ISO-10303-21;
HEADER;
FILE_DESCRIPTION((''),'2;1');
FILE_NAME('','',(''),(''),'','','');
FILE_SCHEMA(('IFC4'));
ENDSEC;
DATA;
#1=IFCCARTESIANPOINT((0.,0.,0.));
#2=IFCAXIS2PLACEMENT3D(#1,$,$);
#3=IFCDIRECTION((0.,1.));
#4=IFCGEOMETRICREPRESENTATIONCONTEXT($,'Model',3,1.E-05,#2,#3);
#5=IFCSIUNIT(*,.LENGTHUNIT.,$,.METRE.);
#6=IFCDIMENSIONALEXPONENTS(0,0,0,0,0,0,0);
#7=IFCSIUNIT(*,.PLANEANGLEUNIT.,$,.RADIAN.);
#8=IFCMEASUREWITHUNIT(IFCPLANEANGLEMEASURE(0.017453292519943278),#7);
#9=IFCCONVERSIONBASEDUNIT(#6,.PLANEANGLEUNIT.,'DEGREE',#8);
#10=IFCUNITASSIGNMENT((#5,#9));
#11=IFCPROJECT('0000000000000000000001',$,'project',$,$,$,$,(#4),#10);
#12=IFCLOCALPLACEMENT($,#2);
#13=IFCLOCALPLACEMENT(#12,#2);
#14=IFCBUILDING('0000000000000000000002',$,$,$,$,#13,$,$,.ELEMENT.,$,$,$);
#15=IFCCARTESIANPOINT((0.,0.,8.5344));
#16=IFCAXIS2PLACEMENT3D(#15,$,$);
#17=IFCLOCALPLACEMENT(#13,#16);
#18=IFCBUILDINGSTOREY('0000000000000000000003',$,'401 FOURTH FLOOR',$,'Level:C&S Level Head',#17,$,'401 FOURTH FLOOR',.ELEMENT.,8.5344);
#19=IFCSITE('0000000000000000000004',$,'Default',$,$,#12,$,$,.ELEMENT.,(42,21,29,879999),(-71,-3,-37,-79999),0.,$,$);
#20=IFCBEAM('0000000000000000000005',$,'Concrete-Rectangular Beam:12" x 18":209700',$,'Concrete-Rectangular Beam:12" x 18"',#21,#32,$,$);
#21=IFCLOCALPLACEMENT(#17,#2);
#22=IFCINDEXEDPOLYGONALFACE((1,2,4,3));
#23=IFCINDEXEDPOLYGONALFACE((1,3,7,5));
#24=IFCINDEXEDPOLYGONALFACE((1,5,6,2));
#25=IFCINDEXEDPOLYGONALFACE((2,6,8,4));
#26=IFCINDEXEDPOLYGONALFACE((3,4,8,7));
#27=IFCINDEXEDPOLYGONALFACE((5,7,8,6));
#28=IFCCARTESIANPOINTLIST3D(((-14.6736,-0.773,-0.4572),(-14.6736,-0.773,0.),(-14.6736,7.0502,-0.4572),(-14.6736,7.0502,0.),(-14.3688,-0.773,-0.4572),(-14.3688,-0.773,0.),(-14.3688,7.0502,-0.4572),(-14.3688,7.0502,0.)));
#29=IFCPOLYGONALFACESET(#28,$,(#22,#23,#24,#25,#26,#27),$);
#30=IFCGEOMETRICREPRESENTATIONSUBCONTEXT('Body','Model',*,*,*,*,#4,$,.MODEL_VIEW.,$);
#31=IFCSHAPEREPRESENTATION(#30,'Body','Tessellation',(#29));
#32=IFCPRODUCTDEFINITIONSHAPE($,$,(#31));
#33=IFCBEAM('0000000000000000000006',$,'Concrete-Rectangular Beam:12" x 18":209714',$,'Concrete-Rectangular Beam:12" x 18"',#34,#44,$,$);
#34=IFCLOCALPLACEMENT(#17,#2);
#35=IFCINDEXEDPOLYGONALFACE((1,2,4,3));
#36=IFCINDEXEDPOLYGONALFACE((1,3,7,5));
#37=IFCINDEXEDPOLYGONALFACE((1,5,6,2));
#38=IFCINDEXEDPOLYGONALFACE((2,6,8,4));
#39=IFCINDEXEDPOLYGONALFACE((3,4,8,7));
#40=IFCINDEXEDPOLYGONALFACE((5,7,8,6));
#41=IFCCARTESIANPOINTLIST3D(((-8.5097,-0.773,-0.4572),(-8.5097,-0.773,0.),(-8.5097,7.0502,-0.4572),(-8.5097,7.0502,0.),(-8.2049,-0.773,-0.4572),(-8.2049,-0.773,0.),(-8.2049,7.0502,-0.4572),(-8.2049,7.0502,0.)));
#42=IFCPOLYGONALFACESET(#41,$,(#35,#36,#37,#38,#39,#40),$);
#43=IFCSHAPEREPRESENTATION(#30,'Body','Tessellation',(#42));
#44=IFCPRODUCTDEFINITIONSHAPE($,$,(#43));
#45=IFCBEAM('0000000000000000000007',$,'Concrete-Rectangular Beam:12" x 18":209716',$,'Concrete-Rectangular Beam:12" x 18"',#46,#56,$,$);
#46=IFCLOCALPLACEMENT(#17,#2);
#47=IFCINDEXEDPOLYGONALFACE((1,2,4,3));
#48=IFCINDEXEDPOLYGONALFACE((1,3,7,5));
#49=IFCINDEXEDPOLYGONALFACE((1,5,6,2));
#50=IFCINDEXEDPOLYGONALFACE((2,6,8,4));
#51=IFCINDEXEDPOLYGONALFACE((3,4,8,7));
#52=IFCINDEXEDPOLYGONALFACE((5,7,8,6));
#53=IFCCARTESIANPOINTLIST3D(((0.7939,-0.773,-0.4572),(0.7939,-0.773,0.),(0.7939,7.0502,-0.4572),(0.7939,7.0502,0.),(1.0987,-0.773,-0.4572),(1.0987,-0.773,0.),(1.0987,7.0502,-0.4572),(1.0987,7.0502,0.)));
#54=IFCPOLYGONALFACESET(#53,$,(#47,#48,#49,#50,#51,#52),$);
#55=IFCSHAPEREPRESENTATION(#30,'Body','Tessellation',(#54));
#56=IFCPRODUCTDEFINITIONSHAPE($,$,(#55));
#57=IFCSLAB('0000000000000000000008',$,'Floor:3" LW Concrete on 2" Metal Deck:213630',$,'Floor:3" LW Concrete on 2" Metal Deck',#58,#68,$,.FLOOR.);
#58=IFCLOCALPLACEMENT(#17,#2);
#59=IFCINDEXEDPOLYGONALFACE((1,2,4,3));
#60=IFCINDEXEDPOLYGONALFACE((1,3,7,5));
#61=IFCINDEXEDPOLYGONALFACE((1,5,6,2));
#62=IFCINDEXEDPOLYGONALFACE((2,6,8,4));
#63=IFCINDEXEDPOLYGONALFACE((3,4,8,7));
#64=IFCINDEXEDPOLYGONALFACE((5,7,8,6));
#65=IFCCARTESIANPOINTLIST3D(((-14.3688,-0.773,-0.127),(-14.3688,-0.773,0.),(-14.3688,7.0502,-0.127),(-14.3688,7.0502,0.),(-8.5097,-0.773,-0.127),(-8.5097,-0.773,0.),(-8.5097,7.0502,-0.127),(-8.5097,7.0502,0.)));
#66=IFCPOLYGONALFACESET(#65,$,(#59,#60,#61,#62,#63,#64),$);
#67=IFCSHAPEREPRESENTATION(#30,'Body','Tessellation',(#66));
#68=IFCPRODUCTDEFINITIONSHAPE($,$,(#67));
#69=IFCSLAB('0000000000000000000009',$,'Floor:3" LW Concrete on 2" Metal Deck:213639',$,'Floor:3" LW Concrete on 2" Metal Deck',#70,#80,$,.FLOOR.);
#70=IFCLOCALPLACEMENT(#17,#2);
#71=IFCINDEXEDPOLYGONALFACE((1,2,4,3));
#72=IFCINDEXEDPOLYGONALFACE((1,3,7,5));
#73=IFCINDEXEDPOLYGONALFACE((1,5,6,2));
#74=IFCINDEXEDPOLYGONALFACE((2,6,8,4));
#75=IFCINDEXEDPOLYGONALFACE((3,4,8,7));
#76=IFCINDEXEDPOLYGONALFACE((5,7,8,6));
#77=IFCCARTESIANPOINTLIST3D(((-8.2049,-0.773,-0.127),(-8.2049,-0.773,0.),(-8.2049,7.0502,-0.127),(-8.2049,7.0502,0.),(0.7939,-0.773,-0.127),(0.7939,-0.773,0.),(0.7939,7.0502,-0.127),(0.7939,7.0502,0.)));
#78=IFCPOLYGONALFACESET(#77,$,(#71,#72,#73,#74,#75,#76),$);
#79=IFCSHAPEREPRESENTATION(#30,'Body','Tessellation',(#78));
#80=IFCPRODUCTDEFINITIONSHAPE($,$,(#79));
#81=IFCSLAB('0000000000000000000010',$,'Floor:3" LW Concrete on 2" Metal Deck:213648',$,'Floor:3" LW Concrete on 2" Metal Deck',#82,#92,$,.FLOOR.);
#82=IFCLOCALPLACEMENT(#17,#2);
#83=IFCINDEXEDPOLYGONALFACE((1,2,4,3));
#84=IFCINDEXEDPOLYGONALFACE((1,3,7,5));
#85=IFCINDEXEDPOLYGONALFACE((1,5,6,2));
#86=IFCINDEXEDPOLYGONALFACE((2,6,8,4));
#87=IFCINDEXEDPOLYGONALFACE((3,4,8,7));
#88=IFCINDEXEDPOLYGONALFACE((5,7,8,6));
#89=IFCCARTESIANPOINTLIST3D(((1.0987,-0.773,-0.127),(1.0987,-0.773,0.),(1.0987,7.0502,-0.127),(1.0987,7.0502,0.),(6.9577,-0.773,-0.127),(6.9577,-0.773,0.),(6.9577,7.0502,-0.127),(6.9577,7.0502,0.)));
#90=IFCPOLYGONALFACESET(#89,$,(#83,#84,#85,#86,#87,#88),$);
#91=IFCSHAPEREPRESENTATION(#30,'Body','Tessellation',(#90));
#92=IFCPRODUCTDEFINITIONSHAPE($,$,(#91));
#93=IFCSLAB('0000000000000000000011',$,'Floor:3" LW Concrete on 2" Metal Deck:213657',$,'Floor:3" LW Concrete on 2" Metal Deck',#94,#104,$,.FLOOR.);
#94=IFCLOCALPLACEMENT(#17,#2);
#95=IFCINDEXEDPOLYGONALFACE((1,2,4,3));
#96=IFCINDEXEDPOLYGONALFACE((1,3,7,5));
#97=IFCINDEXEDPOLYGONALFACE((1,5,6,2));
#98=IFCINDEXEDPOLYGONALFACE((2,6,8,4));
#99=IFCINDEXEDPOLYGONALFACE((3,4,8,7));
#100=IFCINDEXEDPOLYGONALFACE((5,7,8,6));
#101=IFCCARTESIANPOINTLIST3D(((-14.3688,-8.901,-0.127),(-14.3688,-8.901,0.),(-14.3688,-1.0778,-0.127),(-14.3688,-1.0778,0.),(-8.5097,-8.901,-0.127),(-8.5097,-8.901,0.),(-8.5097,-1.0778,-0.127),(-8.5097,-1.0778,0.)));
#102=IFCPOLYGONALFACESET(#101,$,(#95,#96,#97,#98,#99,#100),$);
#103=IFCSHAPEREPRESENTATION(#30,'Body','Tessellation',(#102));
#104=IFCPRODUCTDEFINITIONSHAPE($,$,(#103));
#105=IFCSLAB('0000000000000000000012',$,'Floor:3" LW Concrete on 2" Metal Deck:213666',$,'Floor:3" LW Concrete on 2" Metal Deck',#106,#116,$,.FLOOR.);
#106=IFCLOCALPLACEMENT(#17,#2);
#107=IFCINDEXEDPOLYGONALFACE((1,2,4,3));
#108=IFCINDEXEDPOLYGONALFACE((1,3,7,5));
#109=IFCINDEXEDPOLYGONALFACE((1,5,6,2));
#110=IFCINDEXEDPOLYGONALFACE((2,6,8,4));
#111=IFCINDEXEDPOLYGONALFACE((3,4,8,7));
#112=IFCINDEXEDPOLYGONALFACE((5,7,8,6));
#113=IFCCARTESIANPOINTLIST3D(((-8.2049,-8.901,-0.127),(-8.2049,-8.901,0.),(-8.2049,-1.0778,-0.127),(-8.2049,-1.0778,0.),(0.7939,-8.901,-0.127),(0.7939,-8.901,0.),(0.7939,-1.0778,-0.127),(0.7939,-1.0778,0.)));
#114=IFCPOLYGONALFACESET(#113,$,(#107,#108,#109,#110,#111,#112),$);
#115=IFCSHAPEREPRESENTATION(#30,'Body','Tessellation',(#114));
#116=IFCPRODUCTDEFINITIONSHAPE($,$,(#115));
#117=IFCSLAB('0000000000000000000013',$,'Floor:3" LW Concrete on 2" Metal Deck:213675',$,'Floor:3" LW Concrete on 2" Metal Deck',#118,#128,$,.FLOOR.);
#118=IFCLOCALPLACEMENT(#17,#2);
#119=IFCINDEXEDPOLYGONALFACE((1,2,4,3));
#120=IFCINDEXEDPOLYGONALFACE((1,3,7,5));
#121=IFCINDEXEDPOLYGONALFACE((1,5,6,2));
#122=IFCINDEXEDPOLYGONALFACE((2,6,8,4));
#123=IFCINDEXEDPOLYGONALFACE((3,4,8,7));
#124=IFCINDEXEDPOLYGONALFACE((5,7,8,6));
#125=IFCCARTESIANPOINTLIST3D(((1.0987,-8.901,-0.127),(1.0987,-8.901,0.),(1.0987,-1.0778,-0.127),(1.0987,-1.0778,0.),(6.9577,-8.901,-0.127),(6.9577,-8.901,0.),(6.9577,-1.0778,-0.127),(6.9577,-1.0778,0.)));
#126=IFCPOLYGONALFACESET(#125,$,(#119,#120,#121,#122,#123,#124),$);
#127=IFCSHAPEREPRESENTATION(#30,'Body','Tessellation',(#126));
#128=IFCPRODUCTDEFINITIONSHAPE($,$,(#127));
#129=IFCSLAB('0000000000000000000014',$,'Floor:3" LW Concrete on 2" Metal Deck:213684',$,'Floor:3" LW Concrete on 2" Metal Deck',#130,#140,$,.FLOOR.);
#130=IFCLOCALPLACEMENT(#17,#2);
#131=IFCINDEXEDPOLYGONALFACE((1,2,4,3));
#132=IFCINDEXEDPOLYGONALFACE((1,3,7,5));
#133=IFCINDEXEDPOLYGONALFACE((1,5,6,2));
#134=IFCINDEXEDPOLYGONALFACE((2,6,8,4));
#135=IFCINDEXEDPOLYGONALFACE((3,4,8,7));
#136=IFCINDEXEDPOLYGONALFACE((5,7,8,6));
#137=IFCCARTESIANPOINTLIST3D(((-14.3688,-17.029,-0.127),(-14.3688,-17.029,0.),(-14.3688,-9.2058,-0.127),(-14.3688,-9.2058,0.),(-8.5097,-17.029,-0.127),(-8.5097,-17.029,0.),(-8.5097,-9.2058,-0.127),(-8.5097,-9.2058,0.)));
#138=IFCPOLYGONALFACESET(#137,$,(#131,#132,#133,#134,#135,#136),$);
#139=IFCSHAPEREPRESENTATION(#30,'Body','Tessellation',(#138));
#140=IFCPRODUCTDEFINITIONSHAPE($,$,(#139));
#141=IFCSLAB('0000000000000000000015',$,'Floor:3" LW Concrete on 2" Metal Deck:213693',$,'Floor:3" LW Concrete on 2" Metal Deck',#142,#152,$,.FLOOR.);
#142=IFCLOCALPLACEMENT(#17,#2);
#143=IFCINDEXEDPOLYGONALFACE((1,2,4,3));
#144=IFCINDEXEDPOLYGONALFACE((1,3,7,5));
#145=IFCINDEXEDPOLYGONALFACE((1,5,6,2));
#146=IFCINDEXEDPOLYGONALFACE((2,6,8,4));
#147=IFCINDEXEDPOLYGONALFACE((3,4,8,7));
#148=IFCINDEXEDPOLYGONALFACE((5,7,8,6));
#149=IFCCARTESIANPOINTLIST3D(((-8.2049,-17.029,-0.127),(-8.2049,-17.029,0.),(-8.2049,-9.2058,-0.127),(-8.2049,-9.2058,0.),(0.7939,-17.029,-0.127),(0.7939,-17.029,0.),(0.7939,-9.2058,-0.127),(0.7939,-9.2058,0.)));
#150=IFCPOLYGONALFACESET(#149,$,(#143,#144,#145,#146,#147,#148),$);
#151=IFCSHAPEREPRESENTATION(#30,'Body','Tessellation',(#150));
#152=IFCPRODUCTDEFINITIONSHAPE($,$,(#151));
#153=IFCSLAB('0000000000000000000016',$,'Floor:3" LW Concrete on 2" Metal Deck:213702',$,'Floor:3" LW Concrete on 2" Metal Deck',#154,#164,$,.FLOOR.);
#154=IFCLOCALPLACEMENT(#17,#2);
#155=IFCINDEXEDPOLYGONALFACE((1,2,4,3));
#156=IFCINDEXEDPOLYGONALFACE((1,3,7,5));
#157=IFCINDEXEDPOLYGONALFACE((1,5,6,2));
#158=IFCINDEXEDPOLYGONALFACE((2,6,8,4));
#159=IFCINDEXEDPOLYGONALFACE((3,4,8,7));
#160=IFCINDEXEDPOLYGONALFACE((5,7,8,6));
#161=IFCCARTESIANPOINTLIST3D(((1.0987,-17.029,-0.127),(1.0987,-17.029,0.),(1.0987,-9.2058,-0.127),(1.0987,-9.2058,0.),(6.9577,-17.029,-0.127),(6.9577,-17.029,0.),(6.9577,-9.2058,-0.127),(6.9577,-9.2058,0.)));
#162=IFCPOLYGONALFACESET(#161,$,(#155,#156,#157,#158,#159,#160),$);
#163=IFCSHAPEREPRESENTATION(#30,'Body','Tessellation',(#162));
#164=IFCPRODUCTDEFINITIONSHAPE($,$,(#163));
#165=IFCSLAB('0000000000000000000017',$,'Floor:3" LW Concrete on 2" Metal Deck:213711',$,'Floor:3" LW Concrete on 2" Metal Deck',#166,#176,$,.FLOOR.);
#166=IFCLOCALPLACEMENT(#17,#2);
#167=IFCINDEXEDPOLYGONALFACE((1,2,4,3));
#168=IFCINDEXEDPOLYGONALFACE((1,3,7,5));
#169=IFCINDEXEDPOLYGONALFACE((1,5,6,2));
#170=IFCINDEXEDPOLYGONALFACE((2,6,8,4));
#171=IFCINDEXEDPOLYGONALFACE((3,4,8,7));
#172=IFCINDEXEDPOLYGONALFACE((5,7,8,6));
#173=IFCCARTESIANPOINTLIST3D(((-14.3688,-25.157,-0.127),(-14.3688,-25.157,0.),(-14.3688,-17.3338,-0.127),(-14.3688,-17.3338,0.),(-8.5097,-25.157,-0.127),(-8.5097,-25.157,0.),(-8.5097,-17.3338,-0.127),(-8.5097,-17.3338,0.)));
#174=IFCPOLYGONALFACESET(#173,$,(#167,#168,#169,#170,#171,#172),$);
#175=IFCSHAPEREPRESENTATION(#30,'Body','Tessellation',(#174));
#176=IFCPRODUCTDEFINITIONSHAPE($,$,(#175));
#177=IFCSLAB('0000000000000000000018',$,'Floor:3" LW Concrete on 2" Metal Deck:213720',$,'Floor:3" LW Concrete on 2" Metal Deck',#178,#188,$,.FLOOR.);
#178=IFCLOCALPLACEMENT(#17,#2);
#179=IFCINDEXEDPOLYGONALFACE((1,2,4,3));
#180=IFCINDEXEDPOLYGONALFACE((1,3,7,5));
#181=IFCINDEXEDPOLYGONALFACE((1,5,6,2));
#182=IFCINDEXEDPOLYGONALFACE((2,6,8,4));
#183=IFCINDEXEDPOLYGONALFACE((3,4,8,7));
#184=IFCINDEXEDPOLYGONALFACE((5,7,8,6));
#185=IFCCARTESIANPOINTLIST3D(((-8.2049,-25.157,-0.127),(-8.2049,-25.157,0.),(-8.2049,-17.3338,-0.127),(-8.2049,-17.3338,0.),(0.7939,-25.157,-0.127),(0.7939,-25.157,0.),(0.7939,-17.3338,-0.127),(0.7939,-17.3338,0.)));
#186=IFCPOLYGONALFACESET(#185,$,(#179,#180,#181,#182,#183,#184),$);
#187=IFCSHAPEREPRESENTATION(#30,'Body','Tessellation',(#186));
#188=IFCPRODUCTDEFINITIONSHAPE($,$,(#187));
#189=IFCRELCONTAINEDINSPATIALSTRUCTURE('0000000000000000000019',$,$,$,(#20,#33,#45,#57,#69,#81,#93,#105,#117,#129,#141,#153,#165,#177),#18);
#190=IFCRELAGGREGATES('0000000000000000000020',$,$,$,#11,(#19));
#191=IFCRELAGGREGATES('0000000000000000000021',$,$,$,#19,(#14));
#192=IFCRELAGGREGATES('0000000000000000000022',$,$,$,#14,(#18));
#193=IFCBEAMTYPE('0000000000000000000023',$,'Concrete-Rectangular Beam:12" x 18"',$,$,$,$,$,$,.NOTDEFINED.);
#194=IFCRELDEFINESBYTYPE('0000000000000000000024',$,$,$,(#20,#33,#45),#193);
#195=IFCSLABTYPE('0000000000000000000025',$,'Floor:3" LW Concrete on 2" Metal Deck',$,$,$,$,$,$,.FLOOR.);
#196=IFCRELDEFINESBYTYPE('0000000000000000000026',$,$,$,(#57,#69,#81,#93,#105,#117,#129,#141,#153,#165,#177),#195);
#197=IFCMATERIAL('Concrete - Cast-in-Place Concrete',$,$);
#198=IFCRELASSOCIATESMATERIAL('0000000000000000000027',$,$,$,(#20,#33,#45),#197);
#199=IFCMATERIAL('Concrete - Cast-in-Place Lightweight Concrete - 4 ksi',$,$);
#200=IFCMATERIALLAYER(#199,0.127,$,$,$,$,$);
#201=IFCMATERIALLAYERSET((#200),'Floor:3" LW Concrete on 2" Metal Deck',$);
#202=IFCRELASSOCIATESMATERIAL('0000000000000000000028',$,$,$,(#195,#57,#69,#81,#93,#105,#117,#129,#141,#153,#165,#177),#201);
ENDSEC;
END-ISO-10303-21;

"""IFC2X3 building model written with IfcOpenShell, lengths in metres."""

from ifc_helpers import new_model, entity, si_unit, converted_unit, direction, frame, frame_2d, origin, origin_2d_with_axis, place, context, subcontext, project, spatial, rectangle, extrude, material, layer, layer_set, layer_usage, type_object, element, save


model = new_model("IFC2X3")

# Units and contexts
model_context = context("Model", 3, precision=1e-05, world=origin(), true_north=direction((0.0, 1.0)))
body_context = subcontext(model_context, "Body", "Model", "MODEL_VIEW")
ifc_project = project(units=[si_unit("LENGTHUNIT", "METRE"), converted_unit("PLANEANGLEUNIT", "DEGREE", entity("IfcPlaneAngleMeasure", 0.017453292519943278), si_unit("PLANEANGLEUNIT", "RADIAN"), dimensions=[0, 0, 0, 0, 0, 0, 0])], contexts=[model_context])

# Site, building, storey
site_placement = place(None, origin())
site = spatial("IfcSite", under=ifc_project, at=site_placement, Name="Default", CompositionType="ELEMENT", RefLatitude=(42, 21, 29, 879999), RefLongitude=(-71, -3, -37, -79999), RefElevation=0.0)
building_placement = place(site_placement, origin())
building = spatial("IfcBuilding", under=site, at=building_placement, CompositionType="ELEMENT")
storey_placement = place(building_placement, frame((0.0, 0.0, 8.5344)))
storey = spatial("IfcBuildingStorey", under=building, at=storey_placement, Name="401 FOURTH FLOOR", ObjectType="Level:C&S Level Head", LongName="401 FOURTH FLOOR", CompositionType="ELEMENT", Elevation=8.5344)

# Beams
ifc_material_1 = material(Name="Concrete - Cast-in-Place Concrete")
beam_type = type_object("IfcBeamType", Name="Concrete-Rectangular Beam:12\" x 18\"", PredefinedType="NOTDEFINED")
beam_1_placement = place(storey_placement, frame((-14.5212, 7.0502, 0.0), z_axis=(0.0, 0.0, 1.0), x_axis=(0.0, -1.0, 0.0)))
element("IfcBeam", 1, at=beam_1_placement, inside=storey, type_object=beam_type, material=ifc_material_1, Name="Concrete-Rectangular Beam:12\" x 18\":209700", ObjectType="Concrete-Rectangular Beam:12\" x 18\"", context=body_context, shape_type="SweptSolid", body=[
    extrude(rectangle(XDim=0.4572, YDim=0.3048, at=origin_2d_with_axis()), frame((0.0, 0.0, -0.2286), z_axis=(1.0, 0.0, 0.0), x_axis=(0.0, 0.0, -1.0)), (0.0, 0.0, 1.0), 7.8232),
])
beam_2_placement = place(storey_placement, frame((-8.3573, 7.0502, 0.0), z_axis=(0.0, 0.0, 1.0), x_axis=(0.0, -1.0, 0.0)))
element("IfcBeam", 2, at=beam_2_placement, inside=storey, type_object=beam_type, material=ifc_material_1, Name="Concrete-Rectangular Beam:12\" x 18\":209714", ObjectType="Concrete-Rectangular Beam:12\" x 18\"", context=body_context, shape_type="SweptSolid", body=[
    extrude(rectangle(XDim=0.4572, YDim=0.3048, at=frame_2d((0.0, 0.0), x_axis=(1.0, 0.0))), frame((0.0, 0.0, -0.2286), z_axis=(1.0, 0.0, 0.0), x_axis=(0.0, 0.0, -1.0)), (0.0, 0.0, 1.0), 7.8232),
])
beam_3_placement = place(storey_placement, frame((0.9463, 7.0502, 0.0), z_axis=(0.0, 0.0, 1.0), x_axis=(0.0, -1.0, 0.0)))
element("IfcBeam", 3, at=beam_3_placement, inside=storey, type_object=beam_type, material=ifc_material_1, Name="Concrete-Rectangular Beam:12\" x 18\":209716", ObjectType="Concrete-Rectangular Beam:12\" x 18\"", context=body_context, shape_type="SweptSolid", body=[
    extrude(rectangle(XDim=0.4572, YDim=0.3048, at=origin_2d_with_axis()), frame((0.0, 0.0, -0.2286), z_axis=(1.0, 0.0, 0.0), x_axis=(0.0, 0.0, -1.0)), (0.0, 0.0, 1.0), 7.8232),
])

# Slabs
ifc_material_2 = material(Name="Concrete - Cast-in-Place Lightweight Concrete - 4 ksi")
ifc_layer = layer(ifc_material_2, 0.127)
ifc_layer_set = layer_set([ifc_layer], Name="Floor:3\" LW Concrete on 2\" Metal Deck")
ifc_layer_usage_1 = layer_usage(ifc_layer_set, "AXIS3", "POSITIVE", 0.0)
slab_type = type_object("IfcSlabType", Name="Floor:3\" LW Concrete on 2\" Metal Deck", PredefinedType="FLOOR", material=ifc_layer_set)
slab_1_placement = place(storey_placement, origin())
element("IfcSlab", 4, at=slab_1_placement, inside=storey, type_object=slab_type, material=ifc_layer_usage_1, Name="Floor:3\" LW Concrete on 2\" Metal Deck:213630", ObjectType="Floor:3\" LW Concrete on 2\" Metal Deck", PredefinedType="FLOOR", context=body_context, shape_type="SweptSolid", body=[
    extrude(rectangle(XDim=7.8232, YDim=5.859, at=frame_2d((0.0, 0.0), x_axis=(1.0, 0.0))), frame((-11.4393, 3.1386, 0.0), z_axis=(0.0, 0.0, -1.0), x_axis=(0.0, 1.0, 0.0)), (0.0, 0.0, 1.0), 0.127),
])
ifc_layer_usage_2 = layer_usage(ifc_layer_set, "AXIS3", "POSITIVE", 0.0)
slab_2_placement = place(storey_placement, origin())
element("IfcSlab", 5, at=slab_2_placement, inside=storey, type_object=slab_type, material=ifc_layer_usage_2, Name="Floor:3\" LW Concrete on 2\" Metal Deck:213639", ObjectType="Floor:3\" LW Concrete on 2\" Metal Deck", PredefinedType="FLOOR", context=body_context, shape_type="SweptSolid", body=[
    extrude(rectangle(XDim=7.8232, YDim=8.9988, at=origin_2d_with_axis()), frame((-3.7055, 3.1386, 0.0), z_axis=(0.0, 0.0, -1.0), x_axis=(0.0, 1.0, 0.0)), (0.0, 0.0, 1.0), 0.127),
])
ifc_layer_usage_3 = layer_usage(ifc_layer_set, "AXIS3", "POSITIVE", 0.0)
slab_3_placement = place(storey_placement, origin())
element("IfcSlab", 6, at=slab_3_placement, inside=storey, type_object=slab_type, material=ifc_layer_usage_3, Name="Floor:3\" LW Concrete on 2\" Metal Deck:213648", ObjectType="Floor:3\" LW Concrete on 2\" Metal Deck", PredefinedType="FLOOR", context=body_context, shape_type="SweptSolid", body=[
    extrude(rectangle(XDim=7.8232, YDim=5.859, at=origin_2d_with_axis()), frame((4.0282, 3.1386, 0.0), z_axis=(0.0, 0.0, -1.0), x_axis=(0.0, 1.0, 0.0)), (0.0, 0.0, 1.0), 0.127),
])
ifc_layer_usage_4 = layer_usage(ifc_layer_set, "AXIS3", "POSITIVE", 0.0)
slab_4_placement = place(storey_placement, origin())
element("IfcSlab", 7, at=slab_4_placement, inside=storey, type_object=slab_type, material=ifc_layer_usage_4, Name="Floor:3\" LW Concrete on 2\" Metal Deck:213657", ObjectType="Floor:3\" LW Concrete on 2\" Metal Deck", PredefinedType="FLOOR", context=body_context, shape_type="SweptSolid", body=[
    extrude(rectangle(XDim=7.8232, YDim=5.859, at=origin_2d_with_axis()), frame((-11.4393, -4.9894, 0.0), z_axis=(0.0, 0.0, -1.0), x_axis=(0.0, 1.0, 0.0)), (0.0, 0.0, 1.0), 0.127),
])
ifc_layer_usage_5 = layer_usage(ifc_layer_set, "AXIS3", "POSITIVE", 0.0)
slab_5_placement = place(storey_placement, origin())
element("IfcSlab", 8, at=slab_5_placement, inside=storey, type_object=slab_type, material=ifc_layer_usage_5, Name="Floor:3\" LW Concrete on 2\" Metal Deck:213666", ObjectType="Floor:3\" LW Concrete on 2\" Metal Deck", PredefinedType="FLOOR", context=body_context, shape_type="SweptSolid", body=[
    extrude(rectangle(XDim=7.8232, YDim=8.9988, at=frame_2d((0.0, 0.0), x_axis=(1.0, 0.0))), frame((-3.7055, -4.9894, 0.0), z_axis=(0.0, 0.0, -1.0), x_axis=(0.0, 1.0, 0.0)), (0.0, 0.0, 1.0), 0.127),
])
ifc_layer_usage_6 = layer_usage(ifc_layer_set, "AXIS3", "POSITIVE", 0.0)
slab_6_placement = place(storey_placement, origin())
element("IfcSlab", 9, at=slab_6_placement, inside=storey, type_object=slab_type, material=ifc_layer_usage_6, Name="Floor:3\" LW Concrete on 2\" Metal Deck:213675", ObjectType="Floor:3\" LW Concrete on 2\" Metal Deck", PredefinedType="FLOOR", context=body_context, shape_type="SweptSolid", body=[
    extrude(rectangle(XDim=7.8232, YDim=5.859, at=origin_2d_with_axis()), frame((4.0282, -4.9894, 0.0), z_axis=(0.0, 0.0, -1.0), x_axis=(0.0, 1.0, 0.0)), (0.0, 0.0, 1.0), 0.127),
])
ifc_layer_usage_7 = layer_usage(ifc_layer_set, "AXIS3", "POSITIVE", 0.0)
slab_7_placement = place(storey_placement, origin())
element("IfcSlab", 10, at=slab_7_placement, inside=storey, type_object=slab_type, material=ifc_layer_usage_7, Name="Floor:3\" LW Concrete on 2\" Metal Deck:213684", ObjectType="Floor:3\" LW Concrete on 2\" Metal Deck", PredefinedType="FLOOR", context=body_context, shape_type="SweptSolid", body=[
    extrude(rectangle(XDim=7.8232, YDim=5.859, at=frame_2d((0.0, 0.0), x_axis=(1.0, 0.0))), frame((-11.4393, -13.1174, 0.0), z_axis=(0.0, 0.0, -1.0), x_axis=(0.0, 1.0, 0.0)), (0.0, 0.0, 1.0), 0.127),
])
ifc_layer_usage_8 = layer_usage(ifc_layer_set, "AXIS3", "POSITIVE", 0.0)
slab_8_placement = place(storey_placement, origin())
element("IfcSlab", 11, at=slab_8_placement, inside=storey, type_object=slab_type, material=ifc_layer_usage_8, Name="Floor:3\" LW Concrete on 2\" Metal Deck:213693", ObjectType="Floor:3\" LW Concrete on 2\" Metal Deck", PredefinedType="FLOOR", context=body_context, shape_type="SweptSolid", body=[
    extrude(rectangle(XDim=7.8232, YDim=8.9988, at=frame_2d((0.0, 0.0), x_axis=(1.0, 0.0))), frame((-3.7055, -13.1174, 0.0), z_axis=(0.0, 0.0, -1.0), x_axis=(0.0, 1.0, 0.0)), (0.0, 0.0, 1.0), 0.127),
])
ifc_layer_usage_9 = layer_usage(ifc_layer_set, "AXIS3", "POSITIVE", 0.0)
slab_9_placement = place(storey_placement, origin())
element("IfcSlab", 12, at=slab_9_placement, inside=storey, type_object=slab_type, material=ifc_layer_usage_9, Name="Floor:3\" LW Concrete on 2\" Metal Deck:213702", ObjectType="Floor:3\" LW Concrete on 2\" Metal Deck", PredefinedType="FLOOR", context=body_context, shape_type="SweptSolid", body=[
    extrude(rectangle(XDim=7.8232, YDim=5.859, at=frame_2d((0.0, 0.0), x_axis=(1.0, 0.0))), frame((4.0282, -13.1174, 0.0), z_axis=(0.0, 0.0, -1.0), x_axis=(0.0, 1.0, 0.0)), (0.0, 0.0, 1.0), 0.127),
])
ifc_layer_usage_10 = layer_usage(ifc_layer_set, "AXIS3", "POSITIVE", 0.0)
slab_10_placement = place(storey_placement, origin())
element("IfcSlab", 13, at=slab_10_placement, inside=storey, type_object=slab_type, material=ifc_layer_usage_10, Name="Floor:3\" LW Concrete on 2\" Metal Deck:213711", ObjectType="Floor:3\" LW Concrete on 2\" Metal Deck", PredefinedType="FLOOR", context=body_context, shape_type="SweptSolid", body=[
    extrude(rectangle(XDim=7.8232, YDim=5.859, at=frame_2d((0.0, 0.0), x_axis=(1.0, 0.0))), frame((-11.4393, -21.2454, 0.0), z_axis=(0.0, 0.0, -1.0), x_axis=(0.0, 1.0, 0.0)), (0.0, 0.0, 1.0), 0.127),
])
ifc_layer_usage_11 = layer_usage(ifc_layer_set, "AXIS3", "POSITIVE", 0.0)
slab_11_placement = place(storey_placement, origin())
element("IfcSlab", 14, at=slab_11_placement, inside=storey, type_object=slab_type, material=ifc_layer_usage_11, Name="Floor:3\" LW Concrete on 2\" Metal Deck:213720", ObjectType="Floor:3\" LW Concrete on 2\" Metal Deck", PredefinedType="FLOOR", context=body_context, shape_type="SweptSolid", body=[
    extrude(rectangle(XDim=7.8232, YDim=8.9988, at=frame_2d((0.0, 0.0), x_axis=(1.0, 0.0))), frame((-3.7055, -21.2454, 0.0), z_axis=(0.0, 0.0, -1.0), x_axis=(0.0, 1.0, 0.0)), (0.0, 0.0, 1.0), 0.127),
])

save(model, "model.ifc")
